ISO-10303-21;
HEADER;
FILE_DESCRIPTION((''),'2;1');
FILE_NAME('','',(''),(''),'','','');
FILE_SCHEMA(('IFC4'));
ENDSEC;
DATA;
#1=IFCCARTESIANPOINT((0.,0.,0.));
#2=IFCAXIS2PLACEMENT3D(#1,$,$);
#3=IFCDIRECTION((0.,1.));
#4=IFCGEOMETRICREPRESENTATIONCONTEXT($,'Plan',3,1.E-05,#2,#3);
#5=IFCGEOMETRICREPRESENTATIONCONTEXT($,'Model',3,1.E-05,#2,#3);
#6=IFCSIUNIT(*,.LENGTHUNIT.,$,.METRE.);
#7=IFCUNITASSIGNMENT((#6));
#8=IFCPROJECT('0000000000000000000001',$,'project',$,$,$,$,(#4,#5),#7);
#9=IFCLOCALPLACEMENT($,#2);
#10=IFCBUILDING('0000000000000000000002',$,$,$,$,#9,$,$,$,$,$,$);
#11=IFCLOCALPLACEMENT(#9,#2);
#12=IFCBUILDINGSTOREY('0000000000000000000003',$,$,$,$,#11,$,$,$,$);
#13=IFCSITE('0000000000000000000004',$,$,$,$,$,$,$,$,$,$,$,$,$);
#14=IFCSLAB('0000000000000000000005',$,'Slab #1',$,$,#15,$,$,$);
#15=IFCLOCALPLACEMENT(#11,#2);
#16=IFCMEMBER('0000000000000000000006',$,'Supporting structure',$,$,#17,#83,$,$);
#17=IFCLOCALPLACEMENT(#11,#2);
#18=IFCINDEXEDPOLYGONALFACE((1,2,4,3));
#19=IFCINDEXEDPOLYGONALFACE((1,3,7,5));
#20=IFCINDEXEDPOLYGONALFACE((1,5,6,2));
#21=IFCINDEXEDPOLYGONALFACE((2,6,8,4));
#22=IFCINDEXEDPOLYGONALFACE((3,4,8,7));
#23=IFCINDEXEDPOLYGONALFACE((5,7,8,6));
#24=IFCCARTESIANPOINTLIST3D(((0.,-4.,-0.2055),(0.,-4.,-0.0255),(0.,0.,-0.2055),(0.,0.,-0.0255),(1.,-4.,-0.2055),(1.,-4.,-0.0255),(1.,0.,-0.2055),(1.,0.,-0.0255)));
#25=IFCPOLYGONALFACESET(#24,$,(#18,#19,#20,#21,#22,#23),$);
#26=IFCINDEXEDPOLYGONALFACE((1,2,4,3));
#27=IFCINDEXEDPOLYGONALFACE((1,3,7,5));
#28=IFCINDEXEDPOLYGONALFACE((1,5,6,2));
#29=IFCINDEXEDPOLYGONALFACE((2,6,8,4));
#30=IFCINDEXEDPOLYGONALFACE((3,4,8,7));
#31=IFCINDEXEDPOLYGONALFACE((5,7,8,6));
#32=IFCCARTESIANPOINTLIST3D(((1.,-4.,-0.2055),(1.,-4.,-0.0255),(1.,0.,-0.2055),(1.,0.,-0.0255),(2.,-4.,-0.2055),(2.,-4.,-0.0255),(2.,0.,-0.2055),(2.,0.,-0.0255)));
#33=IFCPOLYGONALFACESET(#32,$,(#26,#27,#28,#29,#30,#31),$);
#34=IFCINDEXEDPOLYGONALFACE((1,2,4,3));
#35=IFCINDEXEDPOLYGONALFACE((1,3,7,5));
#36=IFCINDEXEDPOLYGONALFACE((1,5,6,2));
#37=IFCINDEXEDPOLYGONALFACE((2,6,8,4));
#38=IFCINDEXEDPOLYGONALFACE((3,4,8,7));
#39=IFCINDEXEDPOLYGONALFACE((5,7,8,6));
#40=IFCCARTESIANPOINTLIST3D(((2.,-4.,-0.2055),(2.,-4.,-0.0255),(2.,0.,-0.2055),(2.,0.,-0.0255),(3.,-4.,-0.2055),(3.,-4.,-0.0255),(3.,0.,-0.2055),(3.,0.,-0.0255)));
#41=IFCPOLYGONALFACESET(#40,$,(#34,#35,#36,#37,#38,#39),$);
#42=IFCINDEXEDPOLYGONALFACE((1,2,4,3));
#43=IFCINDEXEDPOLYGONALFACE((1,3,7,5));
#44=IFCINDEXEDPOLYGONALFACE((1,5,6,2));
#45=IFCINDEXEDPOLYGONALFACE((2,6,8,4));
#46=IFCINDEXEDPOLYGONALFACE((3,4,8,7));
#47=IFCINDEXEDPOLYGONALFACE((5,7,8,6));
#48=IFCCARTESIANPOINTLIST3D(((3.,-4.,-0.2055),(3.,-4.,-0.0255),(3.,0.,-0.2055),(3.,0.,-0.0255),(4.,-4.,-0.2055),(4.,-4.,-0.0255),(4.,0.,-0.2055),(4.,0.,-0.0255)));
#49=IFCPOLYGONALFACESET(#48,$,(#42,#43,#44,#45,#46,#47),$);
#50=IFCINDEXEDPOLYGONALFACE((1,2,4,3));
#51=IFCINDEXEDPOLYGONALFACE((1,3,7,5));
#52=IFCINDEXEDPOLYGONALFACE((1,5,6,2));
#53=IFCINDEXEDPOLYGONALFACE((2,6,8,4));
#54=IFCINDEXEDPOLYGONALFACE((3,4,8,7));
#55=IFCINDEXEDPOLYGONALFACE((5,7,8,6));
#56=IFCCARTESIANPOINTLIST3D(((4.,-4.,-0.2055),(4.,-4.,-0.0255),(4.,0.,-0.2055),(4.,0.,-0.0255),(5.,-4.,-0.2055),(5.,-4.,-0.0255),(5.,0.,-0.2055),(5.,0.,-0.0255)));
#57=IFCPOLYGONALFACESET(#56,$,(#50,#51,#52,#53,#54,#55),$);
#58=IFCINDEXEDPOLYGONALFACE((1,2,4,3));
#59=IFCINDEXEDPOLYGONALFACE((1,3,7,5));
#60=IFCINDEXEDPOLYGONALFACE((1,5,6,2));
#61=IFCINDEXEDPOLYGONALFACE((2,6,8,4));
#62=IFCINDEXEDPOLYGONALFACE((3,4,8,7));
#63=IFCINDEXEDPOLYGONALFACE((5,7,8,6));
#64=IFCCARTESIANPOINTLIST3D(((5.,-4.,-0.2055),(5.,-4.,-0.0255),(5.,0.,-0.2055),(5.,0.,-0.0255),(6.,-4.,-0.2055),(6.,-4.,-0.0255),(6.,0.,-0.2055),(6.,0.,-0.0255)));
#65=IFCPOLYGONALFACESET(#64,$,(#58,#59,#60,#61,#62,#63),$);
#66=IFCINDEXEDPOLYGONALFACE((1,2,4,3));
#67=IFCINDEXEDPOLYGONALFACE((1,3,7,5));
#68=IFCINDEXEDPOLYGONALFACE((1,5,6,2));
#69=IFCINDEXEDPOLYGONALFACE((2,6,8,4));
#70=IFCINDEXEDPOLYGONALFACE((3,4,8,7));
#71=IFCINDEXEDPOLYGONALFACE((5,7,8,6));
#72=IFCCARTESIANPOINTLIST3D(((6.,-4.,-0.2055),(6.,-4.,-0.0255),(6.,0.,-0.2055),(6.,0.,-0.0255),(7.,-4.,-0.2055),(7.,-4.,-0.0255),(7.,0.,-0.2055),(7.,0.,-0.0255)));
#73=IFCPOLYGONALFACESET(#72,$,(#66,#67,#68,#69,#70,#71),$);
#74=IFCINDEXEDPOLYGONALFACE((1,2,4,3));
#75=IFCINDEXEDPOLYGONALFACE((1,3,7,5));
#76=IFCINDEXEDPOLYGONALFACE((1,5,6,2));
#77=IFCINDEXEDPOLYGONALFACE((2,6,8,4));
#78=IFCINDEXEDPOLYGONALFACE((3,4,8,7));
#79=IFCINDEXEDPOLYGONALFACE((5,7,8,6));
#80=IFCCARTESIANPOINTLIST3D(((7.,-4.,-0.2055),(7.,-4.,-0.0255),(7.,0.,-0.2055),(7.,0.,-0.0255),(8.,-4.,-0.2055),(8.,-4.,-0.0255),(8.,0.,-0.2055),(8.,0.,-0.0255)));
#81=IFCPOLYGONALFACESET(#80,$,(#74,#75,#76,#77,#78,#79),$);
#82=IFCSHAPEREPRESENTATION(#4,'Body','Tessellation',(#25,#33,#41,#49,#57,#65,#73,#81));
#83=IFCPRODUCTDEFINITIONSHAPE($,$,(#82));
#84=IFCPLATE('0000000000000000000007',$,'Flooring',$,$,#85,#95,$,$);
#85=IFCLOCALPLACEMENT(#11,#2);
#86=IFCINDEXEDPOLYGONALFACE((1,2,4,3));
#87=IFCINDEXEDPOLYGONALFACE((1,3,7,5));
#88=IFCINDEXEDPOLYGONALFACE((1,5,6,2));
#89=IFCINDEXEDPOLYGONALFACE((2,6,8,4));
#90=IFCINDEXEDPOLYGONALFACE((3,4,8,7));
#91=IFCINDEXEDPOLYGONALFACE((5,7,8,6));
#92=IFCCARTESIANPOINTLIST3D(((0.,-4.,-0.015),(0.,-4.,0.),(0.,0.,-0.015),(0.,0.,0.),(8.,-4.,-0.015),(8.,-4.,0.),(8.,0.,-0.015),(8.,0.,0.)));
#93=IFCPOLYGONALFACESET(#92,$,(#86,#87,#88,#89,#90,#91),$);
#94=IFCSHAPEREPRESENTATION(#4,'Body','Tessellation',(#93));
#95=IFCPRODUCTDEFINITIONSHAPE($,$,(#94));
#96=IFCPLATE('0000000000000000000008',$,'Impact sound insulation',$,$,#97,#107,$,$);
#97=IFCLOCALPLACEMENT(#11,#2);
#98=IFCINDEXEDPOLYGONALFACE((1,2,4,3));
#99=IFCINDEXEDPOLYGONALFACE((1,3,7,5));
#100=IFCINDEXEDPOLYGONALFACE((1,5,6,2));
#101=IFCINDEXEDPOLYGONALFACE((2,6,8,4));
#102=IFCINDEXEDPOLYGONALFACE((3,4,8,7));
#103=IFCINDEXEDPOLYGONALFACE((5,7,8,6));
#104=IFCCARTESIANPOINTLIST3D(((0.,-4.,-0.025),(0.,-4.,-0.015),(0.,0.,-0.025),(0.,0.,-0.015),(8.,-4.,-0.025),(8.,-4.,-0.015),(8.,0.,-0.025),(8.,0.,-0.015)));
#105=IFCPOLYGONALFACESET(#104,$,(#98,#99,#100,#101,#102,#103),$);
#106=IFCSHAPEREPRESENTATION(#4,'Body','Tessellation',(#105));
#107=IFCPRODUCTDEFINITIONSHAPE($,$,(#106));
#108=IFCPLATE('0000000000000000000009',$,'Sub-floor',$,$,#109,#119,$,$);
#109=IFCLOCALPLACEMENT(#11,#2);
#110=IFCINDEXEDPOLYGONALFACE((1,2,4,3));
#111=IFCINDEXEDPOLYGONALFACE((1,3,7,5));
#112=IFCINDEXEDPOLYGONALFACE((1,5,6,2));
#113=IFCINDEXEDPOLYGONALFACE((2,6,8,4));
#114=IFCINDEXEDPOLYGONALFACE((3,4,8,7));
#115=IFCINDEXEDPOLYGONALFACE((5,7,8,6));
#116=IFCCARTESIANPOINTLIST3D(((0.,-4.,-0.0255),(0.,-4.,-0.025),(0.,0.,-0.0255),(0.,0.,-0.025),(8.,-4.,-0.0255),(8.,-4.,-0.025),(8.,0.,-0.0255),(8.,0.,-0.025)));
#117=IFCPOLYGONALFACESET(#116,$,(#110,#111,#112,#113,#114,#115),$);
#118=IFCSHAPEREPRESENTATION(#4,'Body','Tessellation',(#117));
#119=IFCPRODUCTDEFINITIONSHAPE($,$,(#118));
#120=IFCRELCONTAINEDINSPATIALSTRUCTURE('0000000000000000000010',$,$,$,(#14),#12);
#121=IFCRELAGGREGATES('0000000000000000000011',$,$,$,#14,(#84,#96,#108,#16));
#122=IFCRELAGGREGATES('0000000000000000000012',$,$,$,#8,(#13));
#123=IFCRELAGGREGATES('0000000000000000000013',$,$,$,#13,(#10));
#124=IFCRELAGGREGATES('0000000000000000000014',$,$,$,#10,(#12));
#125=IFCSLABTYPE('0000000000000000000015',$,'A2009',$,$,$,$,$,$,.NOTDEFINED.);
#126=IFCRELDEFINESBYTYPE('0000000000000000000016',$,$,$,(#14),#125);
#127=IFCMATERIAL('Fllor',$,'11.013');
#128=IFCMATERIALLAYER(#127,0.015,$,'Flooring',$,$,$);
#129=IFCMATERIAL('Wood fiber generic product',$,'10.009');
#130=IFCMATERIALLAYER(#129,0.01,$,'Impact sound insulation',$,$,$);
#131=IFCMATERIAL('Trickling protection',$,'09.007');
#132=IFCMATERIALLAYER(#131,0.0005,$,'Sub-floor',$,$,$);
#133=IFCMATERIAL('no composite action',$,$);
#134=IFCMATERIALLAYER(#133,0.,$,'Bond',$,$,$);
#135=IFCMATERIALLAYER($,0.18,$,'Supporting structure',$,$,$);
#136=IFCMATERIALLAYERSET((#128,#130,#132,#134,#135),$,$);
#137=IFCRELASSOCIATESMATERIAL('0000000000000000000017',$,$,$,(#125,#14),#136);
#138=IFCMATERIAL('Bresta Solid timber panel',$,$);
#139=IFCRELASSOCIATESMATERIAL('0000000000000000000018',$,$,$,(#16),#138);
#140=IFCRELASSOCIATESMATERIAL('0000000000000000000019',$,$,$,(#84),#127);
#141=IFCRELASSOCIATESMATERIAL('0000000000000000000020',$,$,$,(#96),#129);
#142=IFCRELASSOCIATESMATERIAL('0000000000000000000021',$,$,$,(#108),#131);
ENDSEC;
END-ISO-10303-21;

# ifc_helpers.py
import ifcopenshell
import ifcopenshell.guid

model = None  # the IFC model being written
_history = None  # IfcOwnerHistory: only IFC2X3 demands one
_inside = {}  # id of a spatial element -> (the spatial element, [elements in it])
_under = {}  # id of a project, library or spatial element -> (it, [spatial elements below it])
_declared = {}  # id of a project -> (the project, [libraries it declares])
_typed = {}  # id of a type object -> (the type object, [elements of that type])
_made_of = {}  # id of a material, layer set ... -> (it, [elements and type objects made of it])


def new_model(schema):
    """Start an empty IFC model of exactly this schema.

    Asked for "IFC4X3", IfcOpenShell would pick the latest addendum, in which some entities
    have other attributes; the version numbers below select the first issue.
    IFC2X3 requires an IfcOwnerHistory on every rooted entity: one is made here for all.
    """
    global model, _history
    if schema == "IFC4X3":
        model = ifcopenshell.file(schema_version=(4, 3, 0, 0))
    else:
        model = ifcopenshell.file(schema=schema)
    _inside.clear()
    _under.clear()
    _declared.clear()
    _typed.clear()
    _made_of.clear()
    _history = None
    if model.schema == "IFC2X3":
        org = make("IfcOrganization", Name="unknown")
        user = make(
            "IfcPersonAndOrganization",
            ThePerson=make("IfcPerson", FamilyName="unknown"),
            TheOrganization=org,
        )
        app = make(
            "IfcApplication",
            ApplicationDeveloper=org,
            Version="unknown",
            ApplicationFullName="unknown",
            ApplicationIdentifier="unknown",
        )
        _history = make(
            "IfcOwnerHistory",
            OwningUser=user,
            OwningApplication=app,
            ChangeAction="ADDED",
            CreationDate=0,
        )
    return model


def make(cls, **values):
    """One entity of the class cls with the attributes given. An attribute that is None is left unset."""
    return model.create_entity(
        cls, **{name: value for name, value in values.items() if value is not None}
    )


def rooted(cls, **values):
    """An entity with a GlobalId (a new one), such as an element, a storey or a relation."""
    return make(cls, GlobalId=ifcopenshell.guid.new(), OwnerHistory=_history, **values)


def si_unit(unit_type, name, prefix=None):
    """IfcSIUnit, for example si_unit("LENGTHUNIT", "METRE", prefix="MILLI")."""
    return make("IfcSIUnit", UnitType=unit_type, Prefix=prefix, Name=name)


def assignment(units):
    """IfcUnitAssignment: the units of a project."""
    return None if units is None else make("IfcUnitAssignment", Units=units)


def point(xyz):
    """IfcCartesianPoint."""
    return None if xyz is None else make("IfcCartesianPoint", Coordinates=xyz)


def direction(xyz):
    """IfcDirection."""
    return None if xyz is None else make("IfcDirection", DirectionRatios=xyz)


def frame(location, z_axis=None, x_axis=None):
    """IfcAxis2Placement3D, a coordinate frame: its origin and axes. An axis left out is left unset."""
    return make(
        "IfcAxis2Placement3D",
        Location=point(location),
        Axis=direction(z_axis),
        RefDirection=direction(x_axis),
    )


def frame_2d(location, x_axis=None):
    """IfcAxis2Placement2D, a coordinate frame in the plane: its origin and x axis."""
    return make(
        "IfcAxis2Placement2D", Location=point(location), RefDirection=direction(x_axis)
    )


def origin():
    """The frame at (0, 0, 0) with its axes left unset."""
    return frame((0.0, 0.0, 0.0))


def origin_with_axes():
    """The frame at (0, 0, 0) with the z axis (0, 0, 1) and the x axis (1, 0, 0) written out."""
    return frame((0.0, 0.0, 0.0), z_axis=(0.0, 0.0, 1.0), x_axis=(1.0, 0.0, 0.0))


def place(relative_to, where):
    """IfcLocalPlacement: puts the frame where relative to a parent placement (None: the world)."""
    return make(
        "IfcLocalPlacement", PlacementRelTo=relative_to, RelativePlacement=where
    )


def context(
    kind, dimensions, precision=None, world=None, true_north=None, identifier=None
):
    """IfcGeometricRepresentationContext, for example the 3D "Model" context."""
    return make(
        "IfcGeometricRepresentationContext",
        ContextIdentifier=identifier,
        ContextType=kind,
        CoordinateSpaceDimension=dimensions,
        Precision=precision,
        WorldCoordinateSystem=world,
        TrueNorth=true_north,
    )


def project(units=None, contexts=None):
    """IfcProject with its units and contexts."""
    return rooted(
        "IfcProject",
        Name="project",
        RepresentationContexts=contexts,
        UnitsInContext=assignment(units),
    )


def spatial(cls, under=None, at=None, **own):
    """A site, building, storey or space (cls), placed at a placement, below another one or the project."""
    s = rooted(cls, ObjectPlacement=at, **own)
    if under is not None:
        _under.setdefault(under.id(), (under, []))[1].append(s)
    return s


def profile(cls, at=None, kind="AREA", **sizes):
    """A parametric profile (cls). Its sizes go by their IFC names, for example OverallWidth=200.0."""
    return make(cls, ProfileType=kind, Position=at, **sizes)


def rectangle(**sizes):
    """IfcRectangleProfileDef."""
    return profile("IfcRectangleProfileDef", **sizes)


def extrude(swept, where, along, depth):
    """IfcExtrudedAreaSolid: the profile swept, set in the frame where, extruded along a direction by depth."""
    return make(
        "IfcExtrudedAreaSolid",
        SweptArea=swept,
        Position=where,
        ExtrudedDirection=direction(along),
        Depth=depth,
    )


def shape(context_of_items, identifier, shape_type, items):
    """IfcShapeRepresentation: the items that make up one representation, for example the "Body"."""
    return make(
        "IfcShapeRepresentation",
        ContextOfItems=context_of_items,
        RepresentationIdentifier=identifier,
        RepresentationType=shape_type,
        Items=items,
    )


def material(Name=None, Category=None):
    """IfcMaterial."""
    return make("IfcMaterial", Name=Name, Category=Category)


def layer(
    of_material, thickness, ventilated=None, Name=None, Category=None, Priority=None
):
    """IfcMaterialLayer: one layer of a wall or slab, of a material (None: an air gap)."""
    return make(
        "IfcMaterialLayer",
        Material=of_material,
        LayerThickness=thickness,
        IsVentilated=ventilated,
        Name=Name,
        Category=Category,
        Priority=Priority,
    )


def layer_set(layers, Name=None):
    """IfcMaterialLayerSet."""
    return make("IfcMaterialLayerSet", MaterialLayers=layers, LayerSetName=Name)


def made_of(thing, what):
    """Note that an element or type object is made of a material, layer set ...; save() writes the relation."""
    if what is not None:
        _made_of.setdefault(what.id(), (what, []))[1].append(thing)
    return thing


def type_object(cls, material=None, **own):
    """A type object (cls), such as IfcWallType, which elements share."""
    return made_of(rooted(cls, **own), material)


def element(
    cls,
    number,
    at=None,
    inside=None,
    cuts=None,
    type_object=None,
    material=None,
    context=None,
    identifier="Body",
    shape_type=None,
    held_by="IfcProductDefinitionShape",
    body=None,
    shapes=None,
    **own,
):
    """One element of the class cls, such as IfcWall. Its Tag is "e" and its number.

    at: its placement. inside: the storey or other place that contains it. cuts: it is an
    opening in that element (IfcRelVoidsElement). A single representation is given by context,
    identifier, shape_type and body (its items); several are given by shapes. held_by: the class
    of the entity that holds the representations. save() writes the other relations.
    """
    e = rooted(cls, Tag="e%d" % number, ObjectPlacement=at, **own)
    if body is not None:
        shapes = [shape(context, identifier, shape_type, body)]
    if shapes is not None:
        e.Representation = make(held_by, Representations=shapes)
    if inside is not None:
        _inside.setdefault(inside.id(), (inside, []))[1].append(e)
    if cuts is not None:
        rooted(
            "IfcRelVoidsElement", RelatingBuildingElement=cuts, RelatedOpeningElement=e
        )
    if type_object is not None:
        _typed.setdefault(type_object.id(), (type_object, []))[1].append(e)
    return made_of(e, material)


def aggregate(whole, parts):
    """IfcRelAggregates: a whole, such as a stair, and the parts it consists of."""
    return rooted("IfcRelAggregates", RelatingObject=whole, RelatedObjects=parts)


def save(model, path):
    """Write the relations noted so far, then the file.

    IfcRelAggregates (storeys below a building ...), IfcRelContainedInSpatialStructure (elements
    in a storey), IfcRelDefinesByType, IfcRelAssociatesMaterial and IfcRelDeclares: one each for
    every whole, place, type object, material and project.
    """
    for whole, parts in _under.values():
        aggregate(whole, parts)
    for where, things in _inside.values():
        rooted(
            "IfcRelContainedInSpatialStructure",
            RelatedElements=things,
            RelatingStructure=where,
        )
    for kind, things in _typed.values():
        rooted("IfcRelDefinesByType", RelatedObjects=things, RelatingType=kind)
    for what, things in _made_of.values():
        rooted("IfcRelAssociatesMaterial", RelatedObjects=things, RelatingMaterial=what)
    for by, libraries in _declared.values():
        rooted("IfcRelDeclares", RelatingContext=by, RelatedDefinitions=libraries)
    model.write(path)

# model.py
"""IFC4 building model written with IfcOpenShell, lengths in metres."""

from ifc_helpers import new_model, si_unit, direction, frame, frame_2d, origin, origin_with_axes, place, context, project, spatial, rectangle, extrude, material, layer, layer_set, type_object, element, aggregate, save


model = new_model("IFC4")

# Units and contexts
plan_context = context("Plan", 3, precision=1e-05, world=origin(), true_north=direction((0.0, 1.0)))
model_context = context("Model", 3, precision=1e-05, world=origin(), true_north=direction((0.0, 1.0)))
ifc_project = project(units=[si_unit("LENGTHUNIT", "METRE")], contexts=[plan_context, model_context])

# Site, building, storey
site = spatial("IfcSite", under=ifc_project)
building_placement = place(None, origin())
building = spatial("IfcBuilding", under=site, at=building_placement)
storey_placement = place(building_placement, origin())
storey = spatial("IfcBuildingStorey", under=building, at=storey_placement)

# Slab, member, plates
ifc_material_1 = material(Name="Fllor", Category="11.013")
ifc_layer_1 = layer(ifc_material_1, 0.015, Name="Flooring")
ifc_material_2 = material(Name="Wood fiber generic product", Category="10.009")
ifc_layer_2 = layer(ifc_material_2, 0.01, Name="Impact sound insulation")
ifc_material_3 = material(Name="Trickling protection", Category="09.007")
ifc_layer_3 = layer(ifc_material_3, 0.0005, Name="Sub-floor")
ifc_material_4 = material(Name="no composite action")
ifc_layer_4 = layer(ifc_material_4, 0.0, Name="Bond")
ifc_layer_5 = layer(None, 0.18, Name="Supporting structure")
ifc_layer_set = layer_set([ifc_layer_1, ifc_layer_2, ifc_layer_3, ifc_layer_4, ifc_layer_5])
slab_type = type_object("IfcSlabType", Name="A2009", PredefinedType="NOTDEFINED", material=ifc_layer_set)
slab_placement = place(None, frame((0.0, 0.0, 0.0), z_axis=(0.0, 0.0, -1.0), x_axis=(1.0, 0.0, 0.0)))
slab = element("IfcSlab", 1, at=slab_placement, inside=storey, type_object=slab_type, material=ifc_layer_set, Name="Slab #1")
ifc_material_5 = material(Name="Bresta Solid timber panel")
member_placement = place(slab_placement, origin())
member = element("IfcMember", 2, at=member_placement, material=ifc_material_5, Name="Supporting structure", context=plan_context, shape_type="SweptSolid", body=[
    extrude(rectangle(XDim=1.0, YDim=0.18, at=frame_2d((0.5, 0.09), x_axis=(1.0, 0.0))), frame((0.0, 4.0, 0.0255), z_axis=(0.0, -1.0, 0.0), x_axis=(1.0, 0.0, 0.0)), (0.0, 0.0, 1.0), 4.0),
    extrude(rectangle(XDim=1.0, YDim=0.18, at=frame_2d((0.5, 0.09), x_axis=(1.0, 0.0))), frame((1.0, 4.0, 0.0255), z_axis=(0.0, -1.0, 0.0), x_axis=(1.0, 0.0, 0.0)), (0.0, 0.0, 1.0), 4.0),
    extrude(rectangle(XDim=1.0, YDim=0.18, at=frame_2d((0.5, 0.09), x_axis=(1.0, 0.0))), frame((2.0, 4.0, 0.0255), z_axis=(0.0, -1.0, 0.0), x_axis=(1.0, 0.0, 0.0)), (0.0, 0.0, 1.0), 4.0),
    extrude(rectangle(XDim=1.0, YDim=0.18, at=frame_2d((0.5, 0.09), x_axis=(1.0, 0.0))), frame((3.0, 4.0, 0.0255), z_axis=(0.0, -1.0, 0.0), x_axis=(1.0, 0.0, 0.0)), (0.0, 0.0, 1.0), 4.0),
    extrude(rectangle(XDim=1.0, YDim=0.18, at=frame_2d((0.5, 0.09), x_axis=(1.0, 0.0))), frame((4.0, 4.0, 0.0255), z_axis=(0.0, -1.0, 0.0), x_axis=(1.0, 0.0, 0.0)), (0.0, 0.0, 1.0), 4.0),
    extrude(rectangle(XDim=1.0, YDim=0.18, at=frame_2d((0.5, 0.09), x_axis=(1.0, 0.0))), frame((5.0, 4.0, 0.0255), z_axis=(0.0, -1.0, 0.0), x_axis=(1.0, 0.0, 0.0)), (0.0, 0.0, 1.0), 4.0),
    extrude(rectangle(XDim=1.0, YDim=0.18, at=frame_2d((0.5, 0.09), x_axis=(1.0, 0.0))), frame((6.0, 4.0, 0.0255), z_axis=(0.0, -1.0, 0.0), x_axis=(1.0, 0.0, 0.0)), (0.0, 0.0, 1.0), 4.0),
    extrude(rectangle(XDim=1.0, YDim=0.18, at=frame_2d((0.5, 0.09), x_axis=(1.0, 0.0))), frame((7.0, 4.0, 0.0255), z_axis=(0.0, -1.0, 0.0), x_axis=(1.0, 0.0, 0.0)), (0.0, 0.0, 1.0), 4.0),
])
plate_1_placement = place(slab_placement, origin())
plate_1 = element("IfcPlate", 3, at=plate_1_placement, material=ifc_material_1, Name="Flooring", context=plan_context, shape_type="SweptSolid", body=[
    extrude(rectangle(XDim=8.0, YDim=4.0, at=frame_2d((4.0, 2.0), x_axis=(1.0, 0.0))), origin_with_axes(), (0.0, 0.0, 1.0), 0.015),
])
plate_2_placement = place(slab_placement, origin())
plate_2 = element("IfcPlate", 4, at=plate_2_placement, material=ifc_material_2, Name="Impact sound insulation", context=plan_context, shape_type="SweptSolid", body=[
    extrude(rectangle(XDim=8.0, YDim=4.0, at=frame_2d((4.0, 2.0), x_axis=(1.0, 0.0))), frame((0.0, 0.0, 0.015), z_axis=(0.0, 0.0, 1.0), x_axis=(1.0, 0.0, 0.0)), (0.0, 0.0, 1.0), 0.01),
])
plate_3_placement = place(slab_placement, origin())
plate_3 = element("IfcPlate", 5, at=plate_3_placement, material=ifc_material_3, Name="Sub-floor", context=plan_context, shape_type="SweptSolid", body=[
    extrude(rectangle(XDim=8.0, YDim=4.0, at=frame_2d((4.0, 2.0), x_axis=(1.0, 0.0))), frame((0.0, 0.0, 0.025), z_axis=(0.0, 0.0, 1.0), x_axis=(1.0, 0.0, 0.0)), (0.0, 0.0, 1.0), 0.0005),
])
aggregate(slab, [plate_1, plate_2, plate_3, member])

save(model, "model.ifc")
